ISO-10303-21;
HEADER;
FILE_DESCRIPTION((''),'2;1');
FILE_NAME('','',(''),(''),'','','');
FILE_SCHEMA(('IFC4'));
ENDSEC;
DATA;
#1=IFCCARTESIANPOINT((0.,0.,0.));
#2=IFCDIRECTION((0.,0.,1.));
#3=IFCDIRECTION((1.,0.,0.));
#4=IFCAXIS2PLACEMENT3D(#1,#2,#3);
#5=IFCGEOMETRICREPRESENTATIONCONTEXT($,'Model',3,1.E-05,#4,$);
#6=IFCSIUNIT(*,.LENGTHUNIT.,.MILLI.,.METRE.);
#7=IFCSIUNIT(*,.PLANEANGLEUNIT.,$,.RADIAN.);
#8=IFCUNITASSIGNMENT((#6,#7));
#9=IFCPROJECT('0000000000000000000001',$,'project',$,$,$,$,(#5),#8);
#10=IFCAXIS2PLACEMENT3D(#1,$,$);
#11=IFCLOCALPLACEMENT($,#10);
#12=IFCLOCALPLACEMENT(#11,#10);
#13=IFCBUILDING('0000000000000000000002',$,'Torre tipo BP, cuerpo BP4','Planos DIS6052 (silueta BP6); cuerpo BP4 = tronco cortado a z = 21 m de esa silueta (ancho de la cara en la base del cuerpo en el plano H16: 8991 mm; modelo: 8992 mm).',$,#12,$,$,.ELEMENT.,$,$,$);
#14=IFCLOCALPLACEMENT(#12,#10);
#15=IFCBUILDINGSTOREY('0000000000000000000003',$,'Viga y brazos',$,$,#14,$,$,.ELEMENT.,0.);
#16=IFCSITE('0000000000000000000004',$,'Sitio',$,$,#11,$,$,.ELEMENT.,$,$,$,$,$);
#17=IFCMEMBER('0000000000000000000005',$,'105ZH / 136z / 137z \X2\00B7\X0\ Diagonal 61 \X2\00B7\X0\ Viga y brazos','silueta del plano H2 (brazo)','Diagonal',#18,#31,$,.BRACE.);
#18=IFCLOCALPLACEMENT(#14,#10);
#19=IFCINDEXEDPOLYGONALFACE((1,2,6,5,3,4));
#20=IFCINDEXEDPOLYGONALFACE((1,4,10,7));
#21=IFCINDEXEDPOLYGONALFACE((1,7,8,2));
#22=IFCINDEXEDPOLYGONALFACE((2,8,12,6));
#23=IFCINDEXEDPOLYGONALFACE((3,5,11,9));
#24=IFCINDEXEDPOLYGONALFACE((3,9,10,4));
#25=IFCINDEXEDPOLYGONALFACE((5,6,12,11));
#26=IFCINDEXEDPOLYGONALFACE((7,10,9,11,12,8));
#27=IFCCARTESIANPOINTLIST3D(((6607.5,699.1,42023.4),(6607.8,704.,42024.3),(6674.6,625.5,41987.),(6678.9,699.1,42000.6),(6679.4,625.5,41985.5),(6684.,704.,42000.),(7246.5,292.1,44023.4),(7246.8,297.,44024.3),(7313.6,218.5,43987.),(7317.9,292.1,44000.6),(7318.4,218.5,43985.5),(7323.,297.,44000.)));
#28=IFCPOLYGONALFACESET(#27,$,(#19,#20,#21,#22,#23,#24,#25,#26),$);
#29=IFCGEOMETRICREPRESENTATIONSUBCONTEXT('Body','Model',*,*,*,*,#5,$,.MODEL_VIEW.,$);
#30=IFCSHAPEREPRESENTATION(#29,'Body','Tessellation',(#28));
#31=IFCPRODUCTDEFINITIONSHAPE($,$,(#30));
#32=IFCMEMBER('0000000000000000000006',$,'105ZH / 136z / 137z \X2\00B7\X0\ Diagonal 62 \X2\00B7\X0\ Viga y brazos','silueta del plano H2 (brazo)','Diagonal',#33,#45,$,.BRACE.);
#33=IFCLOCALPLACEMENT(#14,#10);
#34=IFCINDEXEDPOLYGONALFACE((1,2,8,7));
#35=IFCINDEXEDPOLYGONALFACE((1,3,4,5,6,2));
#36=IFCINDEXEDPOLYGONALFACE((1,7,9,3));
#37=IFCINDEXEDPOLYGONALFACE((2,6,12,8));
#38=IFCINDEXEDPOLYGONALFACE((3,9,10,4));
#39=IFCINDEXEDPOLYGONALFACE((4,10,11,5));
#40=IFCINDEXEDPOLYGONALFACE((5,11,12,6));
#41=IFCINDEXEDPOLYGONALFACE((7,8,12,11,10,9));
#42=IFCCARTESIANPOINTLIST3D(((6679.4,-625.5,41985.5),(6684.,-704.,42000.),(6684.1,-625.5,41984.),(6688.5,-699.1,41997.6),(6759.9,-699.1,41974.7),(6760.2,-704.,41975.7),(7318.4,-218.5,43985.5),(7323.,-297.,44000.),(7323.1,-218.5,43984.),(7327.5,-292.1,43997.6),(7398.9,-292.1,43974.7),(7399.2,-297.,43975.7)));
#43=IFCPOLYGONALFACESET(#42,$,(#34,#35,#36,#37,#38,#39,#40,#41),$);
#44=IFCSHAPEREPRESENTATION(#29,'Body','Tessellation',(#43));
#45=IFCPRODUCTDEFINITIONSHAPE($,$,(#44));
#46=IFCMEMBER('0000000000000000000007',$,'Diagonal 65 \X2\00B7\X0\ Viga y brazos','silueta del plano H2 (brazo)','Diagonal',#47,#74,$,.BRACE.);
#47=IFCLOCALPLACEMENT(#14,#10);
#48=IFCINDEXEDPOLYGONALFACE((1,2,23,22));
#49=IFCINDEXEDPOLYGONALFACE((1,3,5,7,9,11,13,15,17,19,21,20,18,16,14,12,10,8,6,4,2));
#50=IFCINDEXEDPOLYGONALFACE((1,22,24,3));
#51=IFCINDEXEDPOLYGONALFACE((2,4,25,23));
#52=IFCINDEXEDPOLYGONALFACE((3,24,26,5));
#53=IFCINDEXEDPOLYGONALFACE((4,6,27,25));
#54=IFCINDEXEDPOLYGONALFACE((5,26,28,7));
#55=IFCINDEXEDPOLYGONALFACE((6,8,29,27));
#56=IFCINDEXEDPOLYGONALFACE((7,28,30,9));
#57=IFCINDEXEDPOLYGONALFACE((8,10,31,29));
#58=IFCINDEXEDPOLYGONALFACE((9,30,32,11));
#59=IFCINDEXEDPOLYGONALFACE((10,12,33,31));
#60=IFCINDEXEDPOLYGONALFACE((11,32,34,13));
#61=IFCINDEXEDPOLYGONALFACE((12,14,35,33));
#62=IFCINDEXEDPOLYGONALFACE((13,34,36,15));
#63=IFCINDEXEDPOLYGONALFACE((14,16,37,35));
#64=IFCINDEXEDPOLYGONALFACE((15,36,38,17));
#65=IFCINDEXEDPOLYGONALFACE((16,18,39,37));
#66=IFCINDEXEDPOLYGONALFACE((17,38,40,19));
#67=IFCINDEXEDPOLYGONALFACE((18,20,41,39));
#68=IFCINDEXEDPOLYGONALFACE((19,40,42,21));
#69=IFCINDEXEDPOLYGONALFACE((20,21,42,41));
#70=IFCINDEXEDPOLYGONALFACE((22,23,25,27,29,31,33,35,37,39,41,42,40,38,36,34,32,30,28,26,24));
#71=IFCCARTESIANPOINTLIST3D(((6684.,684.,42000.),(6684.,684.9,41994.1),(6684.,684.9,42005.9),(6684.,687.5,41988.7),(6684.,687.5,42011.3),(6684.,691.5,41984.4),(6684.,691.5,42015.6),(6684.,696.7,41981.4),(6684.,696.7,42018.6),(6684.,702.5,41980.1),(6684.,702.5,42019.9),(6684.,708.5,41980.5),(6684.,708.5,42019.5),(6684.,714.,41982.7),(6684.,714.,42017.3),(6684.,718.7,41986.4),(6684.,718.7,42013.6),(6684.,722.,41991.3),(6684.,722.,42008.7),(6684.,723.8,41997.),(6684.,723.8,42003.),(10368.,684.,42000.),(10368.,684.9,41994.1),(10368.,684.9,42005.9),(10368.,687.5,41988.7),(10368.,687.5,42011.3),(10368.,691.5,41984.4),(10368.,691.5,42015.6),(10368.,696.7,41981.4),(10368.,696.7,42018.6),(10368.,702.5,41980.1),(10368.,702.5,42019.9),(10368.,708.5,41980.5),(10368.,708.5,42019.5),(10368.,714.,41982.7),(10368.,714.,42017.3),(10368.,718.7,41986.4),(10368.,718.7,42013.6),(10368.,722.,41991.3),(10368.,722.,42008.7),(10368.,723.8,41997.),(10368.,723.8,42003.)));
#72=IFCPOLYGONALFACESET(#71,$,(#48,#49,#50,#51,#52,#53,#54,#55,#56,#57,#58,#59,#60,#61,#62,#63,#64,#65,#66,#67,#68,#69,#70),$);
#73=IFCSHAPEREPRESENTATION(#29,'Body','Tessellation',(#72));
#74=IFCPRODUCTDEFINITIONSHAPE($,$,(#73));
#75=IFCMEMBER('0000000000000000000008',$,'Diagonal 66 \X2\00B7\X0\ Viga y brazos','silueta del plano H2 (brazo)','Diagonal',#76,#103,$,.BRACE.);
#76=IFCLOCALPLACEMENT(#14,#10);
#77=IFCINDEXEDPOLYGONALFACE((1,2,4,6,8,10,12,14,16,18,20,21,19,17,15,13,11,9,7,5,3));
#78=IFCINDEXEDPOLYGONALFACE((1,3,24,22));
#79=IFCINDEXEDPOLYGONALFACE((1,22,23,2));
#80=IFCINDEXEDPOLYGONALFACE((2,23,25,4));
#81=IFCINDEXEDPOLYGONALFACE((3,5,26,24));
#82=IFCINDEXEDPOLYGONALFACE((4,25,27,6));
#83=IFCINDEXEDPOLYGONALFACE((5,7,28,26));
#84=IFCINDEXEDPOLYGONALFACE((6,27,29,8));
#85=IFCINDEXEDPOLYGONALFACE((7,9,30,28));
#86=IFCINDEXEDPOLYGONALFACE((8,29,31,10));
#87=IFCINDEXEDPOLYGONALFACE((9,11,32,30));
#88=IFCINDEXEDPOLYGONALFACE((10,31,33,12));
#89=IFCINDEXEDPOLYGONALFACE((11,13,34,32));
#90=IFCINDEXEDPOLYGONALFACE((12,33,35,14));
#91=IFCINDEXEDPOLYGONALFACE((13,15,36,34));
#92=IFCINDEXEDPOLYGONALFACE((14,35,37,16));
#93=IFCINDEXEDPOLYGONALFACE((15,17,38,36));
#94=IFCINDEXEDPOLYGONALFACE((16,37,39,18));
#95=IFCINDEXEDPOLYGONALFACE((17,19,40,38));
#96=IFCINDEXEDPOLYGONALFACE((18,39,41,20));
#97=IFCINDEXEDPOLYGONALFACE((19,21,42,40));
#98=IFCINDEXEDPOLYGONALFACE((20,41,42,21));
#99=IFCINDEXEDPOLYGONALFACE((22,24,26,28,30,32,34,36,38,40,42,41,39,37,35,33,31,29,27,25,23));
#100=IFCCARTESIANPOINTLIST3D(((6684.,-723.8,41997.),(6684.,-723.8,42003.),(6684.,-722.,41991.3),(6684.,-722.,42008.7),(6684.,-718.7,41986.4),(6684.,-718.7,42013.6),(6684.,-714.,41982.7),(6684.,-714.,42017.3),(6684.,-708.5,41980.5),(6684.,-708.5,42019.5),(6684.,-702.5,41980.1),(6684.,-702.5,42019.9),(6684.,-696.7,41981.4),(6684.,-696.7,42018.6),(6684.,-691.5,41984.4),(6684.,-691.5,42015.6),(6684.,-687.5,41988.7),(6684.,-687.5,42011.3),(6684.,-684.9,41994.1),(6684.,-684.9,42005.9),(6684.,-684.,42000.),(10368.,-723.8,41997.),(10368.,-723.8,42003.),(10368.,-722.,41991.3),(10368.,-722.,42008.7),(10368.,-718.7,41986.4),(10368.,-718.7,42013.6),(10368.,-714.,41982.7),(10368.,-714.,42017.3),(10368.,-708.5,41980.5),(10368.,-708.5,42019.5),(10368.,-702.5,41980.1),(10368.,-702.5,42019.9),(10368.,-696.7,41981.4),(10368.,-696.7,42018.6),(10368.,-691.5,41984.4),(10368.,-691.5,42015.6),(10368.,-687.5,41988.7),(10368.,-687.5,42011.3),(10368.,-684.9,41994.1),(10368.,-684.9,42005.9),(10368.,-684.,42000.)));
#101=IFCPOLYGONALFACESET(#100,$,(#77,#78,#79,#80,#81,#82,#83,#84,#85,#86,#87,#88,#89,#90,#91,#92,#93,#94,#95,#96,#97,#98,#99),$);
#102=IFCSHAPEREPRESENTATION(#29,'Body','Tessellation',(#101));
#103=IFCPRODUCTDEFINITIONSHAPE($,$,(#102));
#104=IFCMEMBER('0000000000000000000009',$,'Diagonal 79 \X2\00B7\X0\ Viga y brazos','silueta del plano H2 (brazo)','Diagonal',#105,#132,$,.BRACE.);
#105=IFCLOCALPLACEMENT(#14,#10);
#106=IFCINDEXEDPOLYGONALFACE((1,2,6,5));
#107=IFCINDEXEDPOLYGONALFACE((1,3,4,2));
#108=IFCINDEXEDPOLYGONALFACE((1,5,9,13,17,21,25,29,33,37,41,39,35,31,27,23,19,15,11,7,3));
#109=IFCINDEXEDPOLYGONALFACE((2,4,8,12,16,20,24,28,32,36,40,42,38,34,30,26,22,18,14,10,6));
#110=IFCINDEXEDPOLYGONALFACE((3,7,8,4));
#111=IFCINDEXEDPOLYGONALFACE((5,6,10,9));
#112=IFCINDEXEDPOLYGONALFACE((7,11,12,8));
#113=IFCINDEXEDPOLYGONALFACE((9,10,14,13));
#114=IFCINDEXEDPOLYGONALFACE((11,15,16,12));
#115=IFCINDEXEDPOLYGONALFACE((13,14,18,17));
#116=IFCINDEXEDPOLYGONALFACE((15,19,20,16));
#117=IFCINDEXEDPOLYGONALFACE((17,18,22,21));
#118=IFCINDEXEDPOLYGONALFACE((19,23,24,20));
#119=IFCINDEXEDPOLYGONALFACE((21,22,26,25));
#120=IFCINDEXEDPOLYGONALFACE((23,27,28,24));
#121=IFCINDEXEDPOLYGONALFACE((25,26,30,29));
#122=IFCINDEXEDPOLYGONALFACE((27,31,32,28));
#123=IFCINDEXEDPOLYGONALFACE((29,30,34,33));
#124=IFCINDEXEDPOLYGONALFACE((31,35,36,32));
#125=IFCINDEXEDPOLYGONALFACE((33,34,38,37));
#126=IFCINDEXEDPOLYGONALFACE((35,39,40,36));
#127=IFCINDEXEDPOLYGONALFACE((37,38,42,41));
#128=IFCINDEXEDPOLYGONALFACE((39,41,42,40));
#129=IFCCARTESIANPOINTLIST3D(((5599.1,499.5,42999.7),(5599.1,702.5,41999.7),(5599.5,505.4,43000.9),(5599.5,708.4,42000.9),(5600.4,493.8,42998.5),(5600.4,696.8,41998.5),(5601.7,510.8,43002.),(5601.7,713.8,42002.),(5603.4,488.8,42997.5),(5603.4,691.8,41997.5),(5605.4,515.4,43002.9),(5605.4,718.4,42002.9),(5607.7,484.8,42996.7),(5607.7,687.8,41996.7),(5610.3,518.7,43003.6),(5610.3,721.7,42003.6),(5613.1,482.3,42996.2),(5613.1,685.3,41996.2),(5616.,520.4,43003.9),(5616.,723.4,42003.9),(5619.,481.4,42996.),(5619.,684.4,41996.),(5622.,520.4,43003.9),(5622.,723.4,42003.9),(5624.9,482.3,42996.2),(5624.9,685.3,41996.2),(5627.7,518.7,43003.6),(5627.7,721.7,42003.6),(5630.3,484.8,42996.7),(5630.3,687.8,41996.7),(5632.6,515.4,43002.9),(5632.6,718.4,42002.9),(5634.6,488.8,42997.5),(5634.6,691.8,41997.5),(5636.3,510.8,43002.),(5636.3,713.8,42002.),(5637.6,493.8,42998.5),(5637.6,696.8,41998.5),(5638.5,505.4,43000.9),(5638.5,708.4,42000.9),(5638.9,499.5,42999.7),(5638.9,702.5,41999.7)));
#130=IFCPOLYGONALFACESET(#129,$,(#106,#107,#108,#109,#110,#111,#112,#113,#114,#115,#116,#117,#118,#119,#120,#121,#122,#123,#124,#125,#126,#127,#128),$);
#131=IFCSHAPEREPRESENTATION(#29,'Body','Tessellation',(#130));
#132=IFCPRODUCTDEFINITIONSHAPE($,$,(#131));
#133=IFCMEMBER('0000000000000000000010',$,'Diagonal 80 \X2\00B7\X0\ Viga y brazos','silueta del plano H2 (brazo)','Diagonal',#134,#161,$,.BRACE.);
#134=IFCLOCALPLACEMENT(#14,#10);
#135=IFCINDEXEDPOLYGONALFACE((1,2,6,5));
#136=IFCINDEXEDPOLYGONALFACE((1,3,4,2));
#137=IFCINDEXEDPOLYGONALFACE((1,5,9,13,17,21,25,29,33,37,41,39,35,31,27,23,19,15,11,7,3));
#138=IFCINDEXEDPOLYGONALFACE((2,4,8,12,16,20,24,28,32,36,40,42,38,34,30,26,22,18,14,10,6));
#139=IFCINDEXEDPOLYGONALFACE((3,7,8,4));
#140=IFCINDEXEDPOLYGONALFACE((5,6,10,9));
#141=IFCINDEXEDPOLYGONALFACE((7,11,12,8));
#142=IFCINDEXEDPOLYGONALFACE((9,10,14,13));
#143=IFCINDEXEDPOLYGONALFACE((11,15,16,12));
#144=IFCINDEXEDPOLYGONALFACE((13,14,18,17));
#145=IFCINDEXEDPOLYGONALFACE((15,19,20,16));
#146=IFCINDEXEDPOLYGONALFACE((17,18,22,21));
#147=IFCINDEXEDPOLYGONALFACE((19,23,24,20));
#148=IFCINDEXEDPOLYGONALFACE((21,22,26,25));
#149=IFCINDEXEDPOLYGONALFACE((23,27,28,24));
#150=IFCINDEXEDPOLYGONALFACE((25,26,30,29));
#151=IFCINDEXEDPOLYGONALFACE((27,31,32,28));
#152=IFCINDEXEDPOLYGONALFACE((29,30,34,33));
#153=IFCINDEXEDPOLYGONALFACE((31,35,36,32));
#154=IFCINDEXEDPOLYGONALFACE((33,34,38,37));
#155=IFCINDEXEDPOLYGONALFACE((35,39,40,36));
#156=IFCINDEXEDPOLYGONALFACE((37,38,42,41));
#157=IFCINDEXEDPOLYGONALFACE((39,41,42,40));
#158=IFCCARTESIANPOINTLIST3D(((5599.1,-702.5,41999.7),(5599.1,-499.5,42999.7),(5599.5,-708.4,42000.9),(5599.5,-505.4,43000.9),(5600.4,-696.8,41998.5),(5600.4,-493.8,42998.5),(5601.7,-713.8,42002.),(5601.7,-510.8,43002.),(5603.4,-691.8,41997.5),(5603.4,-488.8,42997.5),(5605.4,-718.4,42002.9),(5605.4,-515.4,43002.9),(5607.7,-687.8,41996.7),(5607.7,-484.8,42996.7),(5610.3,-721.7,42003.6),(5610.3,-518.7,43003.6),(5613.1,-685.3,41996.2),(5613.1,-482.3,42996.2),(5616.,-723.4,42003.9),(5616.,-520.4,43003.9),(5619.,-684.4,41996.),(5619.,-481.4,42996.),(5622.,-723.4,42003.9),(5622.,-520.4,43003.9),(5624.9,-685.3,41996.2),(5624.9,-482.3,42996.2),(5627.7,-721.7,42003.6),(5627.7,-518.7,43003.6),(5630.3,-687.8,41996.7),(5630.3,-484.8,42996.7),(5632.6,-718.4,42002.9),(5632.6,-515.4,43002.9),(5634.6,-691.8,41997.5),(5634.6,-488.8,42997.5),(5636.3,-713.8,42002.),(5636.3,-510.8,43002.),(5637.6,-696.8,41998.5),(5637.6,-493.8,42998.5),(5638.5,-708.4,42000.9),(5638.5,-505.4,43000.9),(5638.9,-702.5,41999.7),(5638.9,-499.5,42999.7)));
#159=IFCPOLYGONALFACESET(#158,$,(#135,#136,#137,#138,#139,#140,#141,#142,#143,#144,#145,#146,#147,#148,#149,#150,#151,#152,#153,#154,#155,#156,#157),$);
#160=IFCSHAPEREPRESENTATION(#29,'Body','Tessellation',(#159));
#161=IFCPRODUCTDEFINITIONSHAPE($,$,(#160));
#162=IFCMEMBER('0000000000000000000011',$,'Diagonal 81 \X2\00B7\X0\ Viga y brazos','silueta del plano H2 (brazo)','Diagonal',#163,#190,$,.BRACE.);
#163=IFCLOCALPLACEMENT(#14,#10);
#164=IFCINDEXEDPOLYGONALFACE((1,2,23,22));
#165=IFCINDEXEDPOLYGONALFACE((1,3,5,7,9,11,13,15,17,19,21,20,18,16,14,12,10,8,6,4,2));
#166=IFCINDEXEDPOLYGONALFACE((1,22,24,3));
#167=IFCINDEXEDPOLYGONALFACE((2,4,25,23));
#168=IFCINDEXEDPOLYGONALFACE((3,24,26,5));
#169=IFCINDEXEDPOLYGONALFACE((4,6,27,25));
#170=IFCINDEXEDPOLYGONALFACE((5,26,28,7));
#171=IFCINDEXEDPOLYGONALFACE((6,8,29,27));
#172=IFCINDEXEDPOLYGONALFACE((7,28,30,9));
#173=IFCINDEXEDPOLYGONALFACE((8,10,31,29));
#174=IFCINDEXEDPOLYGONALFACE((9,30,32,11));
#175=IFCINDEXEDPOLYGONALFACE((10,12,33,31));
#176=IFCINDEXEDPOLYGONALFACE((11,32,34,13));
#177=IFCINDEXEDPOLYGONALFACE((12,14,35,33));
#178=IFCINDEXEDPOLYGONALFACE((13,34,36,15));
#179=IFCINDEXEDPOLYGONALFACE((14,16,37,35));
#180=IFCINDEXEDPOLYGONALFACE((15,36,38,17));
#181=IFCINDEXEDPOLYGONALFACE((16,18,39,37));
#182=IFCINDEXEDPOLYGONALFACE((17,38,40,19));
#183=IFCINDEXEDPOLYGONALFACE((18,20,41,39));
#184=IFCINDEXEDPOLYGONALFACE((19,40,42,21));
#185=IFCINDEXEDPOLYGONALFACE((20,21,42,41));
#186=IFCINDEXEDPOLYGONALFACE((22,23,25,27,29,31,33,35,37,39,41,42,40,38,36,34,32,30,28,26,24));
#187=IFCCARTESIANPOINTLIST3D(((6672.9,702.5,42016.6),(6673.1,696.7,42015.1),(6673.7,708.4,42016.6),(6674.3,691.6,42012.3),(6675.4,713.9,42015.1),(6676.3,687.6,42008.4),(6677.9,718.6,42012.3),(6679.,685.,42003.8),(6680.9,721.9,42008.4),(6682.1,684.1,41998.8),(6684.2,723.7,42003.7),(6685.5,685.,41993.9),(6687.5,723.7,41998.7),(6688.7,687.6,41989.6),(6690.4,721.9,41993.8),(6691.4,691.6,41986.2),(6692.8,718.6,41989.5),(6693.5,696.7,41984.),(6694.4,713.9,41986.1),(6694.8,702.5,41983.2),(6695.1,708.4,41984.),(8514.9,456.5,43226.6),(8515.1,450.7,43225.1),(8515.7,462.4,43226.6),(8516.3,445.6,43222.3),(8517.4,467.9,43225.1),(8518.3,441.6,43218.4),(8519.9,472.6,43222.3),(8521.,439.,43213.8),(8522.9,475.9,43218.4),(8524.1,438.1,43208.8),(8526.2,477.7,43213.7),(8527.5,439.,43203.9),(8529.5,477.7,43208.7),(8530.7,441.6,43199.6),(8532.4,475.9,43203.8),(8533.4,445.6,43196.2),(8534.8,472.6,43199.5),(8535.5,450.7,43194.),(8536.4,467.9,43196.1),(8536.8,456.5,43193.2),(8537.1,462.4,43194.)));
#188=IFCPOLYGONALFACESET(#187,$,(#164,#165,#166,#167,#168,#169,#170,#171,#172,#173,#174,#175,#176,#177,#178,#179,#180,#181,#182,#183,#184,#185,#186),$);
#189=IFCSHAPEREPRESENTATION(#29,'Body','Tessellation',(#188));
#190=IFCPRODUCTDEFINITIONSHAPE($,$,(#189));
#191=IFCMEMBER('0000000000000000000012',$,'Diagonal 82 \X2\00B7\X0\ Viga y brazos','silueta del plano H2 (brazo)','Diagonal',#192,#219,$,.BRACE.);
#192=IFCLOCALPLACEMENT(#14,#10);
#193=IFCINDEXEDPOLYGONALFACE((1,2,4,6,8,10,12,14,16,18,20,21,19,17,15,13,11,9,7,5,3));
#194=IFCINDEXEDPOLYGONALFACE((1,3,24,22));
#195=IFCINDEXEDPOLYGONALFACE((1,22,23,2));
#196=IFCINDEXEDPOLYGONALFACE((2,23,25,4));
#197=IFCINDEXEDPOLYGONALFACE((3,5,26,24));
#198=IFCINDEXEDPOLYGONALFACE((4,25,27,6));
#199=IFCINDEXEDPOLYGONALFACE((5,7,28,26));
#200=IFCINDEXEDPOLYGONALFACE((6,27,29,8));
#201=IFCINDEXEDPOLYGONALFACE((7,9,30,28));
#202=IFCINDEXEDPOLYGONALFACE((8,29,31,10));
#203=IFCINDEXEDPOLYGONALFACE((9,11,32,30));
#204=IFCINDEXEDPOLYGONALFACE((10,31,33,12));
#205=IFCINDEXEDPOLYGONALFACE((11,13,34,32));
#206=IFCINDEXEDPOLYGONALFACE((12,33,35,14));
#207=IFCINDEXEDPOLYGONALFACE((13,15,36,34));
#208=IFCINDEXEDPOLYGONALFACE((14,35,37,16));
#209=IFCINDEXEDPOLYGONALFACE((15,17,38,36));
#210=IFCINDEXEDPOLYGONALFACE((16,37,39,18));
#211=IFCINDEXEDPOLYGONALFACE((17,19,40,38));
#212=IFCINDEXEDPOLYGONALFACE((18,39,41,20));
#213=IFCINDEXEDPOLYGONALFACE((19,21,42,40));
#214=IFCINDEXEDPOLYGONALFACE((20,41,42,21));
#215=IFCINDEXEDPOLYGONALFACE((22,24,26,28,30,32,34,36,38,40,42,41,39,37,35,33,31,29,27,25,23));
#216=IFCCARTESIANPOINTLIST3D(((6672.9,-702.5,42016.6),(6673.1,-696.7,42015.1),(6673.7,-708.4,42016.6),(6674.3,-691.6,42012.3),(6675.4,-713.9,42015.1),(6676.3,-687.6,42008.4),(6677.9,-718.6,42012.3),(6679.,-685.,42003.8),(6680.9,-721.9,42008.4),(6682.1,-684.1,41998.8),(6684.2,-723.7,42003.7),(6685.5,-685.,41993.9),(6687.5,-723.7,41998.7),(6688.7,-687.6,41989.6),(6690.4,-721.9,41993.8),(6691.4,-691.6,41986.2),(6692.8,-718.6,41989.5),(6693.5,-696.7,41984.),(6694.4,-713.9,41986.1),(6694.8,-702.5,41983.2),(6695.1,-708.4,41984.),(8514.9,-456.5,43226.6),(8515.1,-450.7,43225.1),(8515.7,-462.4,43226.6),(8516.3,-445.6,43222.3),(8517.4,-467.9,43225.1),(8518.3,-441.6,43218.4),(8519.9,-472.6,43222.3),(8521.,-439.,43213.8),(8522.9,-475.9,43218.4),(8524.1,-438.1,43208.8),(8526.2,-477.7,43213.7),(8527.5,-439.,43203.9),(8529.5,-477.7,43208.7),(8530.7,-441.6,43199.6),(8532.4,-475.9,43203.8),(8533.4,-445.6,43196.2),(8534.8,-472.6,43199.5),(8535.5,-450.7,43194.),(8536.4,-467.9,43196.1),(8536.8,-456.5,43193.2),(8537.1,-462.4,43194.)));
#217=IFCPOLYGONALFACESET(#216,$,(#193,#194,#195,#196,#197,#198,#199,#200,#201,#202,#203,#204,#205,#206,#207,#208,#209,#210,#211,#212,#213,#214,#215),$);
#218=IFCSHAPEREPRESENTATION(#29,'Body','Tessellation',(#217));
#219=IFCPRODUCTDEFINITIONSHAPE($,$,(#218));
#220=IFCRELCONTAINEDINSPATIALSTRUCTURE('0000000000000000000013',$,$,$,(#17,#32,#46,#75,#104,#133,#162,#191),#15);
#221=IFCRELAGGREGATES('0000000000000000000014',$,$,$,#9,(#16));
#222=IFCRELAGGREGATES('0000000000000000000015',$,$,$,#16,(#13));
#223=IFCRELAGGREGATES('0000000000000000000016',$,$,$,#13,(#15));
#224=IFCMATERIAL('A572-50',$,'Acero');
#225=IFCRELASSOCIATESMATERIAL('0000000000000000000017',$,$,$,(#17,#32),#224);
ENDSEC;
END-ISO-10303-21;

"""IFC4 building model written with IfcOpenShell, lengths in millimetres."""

from ifc_helpers import new_model, si_unit, frame, frame_2d, origin, origin_with_axes, place, context, subcontext, project, spatial, circle, l_section, extrude, material, element, save


model = new_model("IFC4")

# Units and contexts
model_context = context("Model", 3, precision=1e-05, world=origin_with_axes())
body_context = subcontext(model_context, "Body", "Model", "MODEL_VIEW")
ifc_project = project(units=[si_unit("LENGTHUNIT", "METRE", prefix="MILLI"), si_unit("PLANEANGLEUNIT", "RADIAN")], contexts=[model_context])

# Site, building, storey
site_placement = place(None, origin())
site = spatial("IfcSite", under=ifc_project, at=site_placement, Name="Sitio", CompositionType="ELEMENT")
building_placement = place(site_placement, origin())
building = spatial("IfcBuilding", under=site, at=building_placement, Name="Torre tipo BP, cuerpo BP4", Description="Planos DIS6052 (silueta BP6); cuerpo BP4 = tronco cortado a z = 21 m de esa silueta (ancho de la cara en la base del cuerpo en el plano H16: 8991 mm; modelo: 8992 mm).", CompositionType="ELEMENT")
storey_placement = place(building_placement, origin())
storey = spatial("IfcBuildingStorey", under=building, at=storey_placement, Name="Viga y brazos", CompositionType="ELEMENT", Elevation=0.0)

# Members
ifc_material_1 = material(Name="A572-50", Category="Acero")
for number, where, z_axis, x_axis, name in (
    (1, (7323.0, 297.0, 44000.0), (-0.298782, 0.190304, -0.935154), (-0.057918, -0.981725, -0.181276), "105ZH / 136z / 137z · Diagonal 61 · Viga y brazos"),
    (2, (7323.0, -297.0, 44000.0), (-0.298782, -0.190304, -0.935154), (-0.057918, 0.981725, -0.181276), "105ZH / 136z / 137z · Diagonal 62 · Viga y brazos"),
):
    element("IfcMember", number, at=place(storey_placement, frame(where, z_axis=z_axis, x_axis=x_axis)), inside=storey, material=ifc_material_1, Name=name, Description="silueta del plano H2 (brazo)", ObjectType="Diagonal", PredefinedType="BRACE", context=body_context, shape_type="SweptSolid", body=[
        extrude(l_section(Depth=80.0, Width=80.0, Thickness=5.0, at=frame_2d((40.0, 40.0))), None, (0.0, 0.0, 1.0), 2138.7),
    ])
for number, where, z_axis, x_axis, name in (
    (3, (6684.0, 704.0, 42000.0), (1.0, 0.0, 0.0), (0.0, -1.0, 0.0), "Diagonal 65 · Viga y brazos"),
    (4, (6684.0, -704.0, 42000.0), (1.0, 0.0, 0.0), (0.0, 1.0, 0.0), "Diagonal 66 · Viga y brazos"),
):
    element("IfcMember", number, at=place(storey_placement, frame(where, z_axis=z_axis, x_axis=x_axis)), inside=storey, Name=name, Description="silueta del plano H2 (brazo)", ObjectType="Diagonal", PredefinedType="BRACE", context=body_context, shape_type="SweptSolid", body=[
        extrude(circle(Radius=20.0), None, (0.0, 0.0, 1.0), 3684.0),
    ])
for number, where, z_axis, x_axis, name in (
    (5, (5619.0, 704.0, 42000.0), (0.0, -0.198942, 0.980011), (0.0, -0.980011, -0.198942), "Diagonal 79 · Viga y brazos"),
    (6, (5619.0, -704.0, 42000.0), (0.0, 0.198942, 0.980011), (0.0, 0.980011, -0.198942), "Diagonal 80 · Viga y brazos"),
):
    element("IfcMember", number, at=place(storey_placement, frame(where, z_axis=z_axis, x_axis=x_axis)), inside=storey, Name=name, Description="silueta del plano H2 (brazo)", ObjectType="Diagonal", PredefinedType="BRACE", context=body_context, shape_type="SweptSolid", body=[
        extrude(circle(Radius=20.0), None, (0.0, 0.0, 1.0), 1020.4),
    ])
for number, where, z_axis, x_axis, name in (
    (7, (6684.0, 704.0, 42000.0), (0.830642, -0.110933, 0.545644), (-0.092718, -0.993828, -0.060906), "Diagonal 81 · Viga y brazos"),
    (8, (6684.0, -704.0, 42000.0), (0.830642, 0.110933, 0.545644), (-0.092718, 0.993828, -0.060906), "Diagonal 82 · Viga y brazos"),
):
    element("IfcMember", number, at=place(storey_placement, frame(where, z_axis=z_axis, x_axis=x_axis)), inside=storey, Name=name, Description="silueta del plano H2 (brazo)", ObjectType="Diagonal", PredefinedType="BRACE", context=body_context, shape_type="SweptSolid", body=[
        extrude(circle(Radius=20.0), None, (0.0, 0.0, 1.0), 2217.6),
    ])

save(model, "model.ifc")
